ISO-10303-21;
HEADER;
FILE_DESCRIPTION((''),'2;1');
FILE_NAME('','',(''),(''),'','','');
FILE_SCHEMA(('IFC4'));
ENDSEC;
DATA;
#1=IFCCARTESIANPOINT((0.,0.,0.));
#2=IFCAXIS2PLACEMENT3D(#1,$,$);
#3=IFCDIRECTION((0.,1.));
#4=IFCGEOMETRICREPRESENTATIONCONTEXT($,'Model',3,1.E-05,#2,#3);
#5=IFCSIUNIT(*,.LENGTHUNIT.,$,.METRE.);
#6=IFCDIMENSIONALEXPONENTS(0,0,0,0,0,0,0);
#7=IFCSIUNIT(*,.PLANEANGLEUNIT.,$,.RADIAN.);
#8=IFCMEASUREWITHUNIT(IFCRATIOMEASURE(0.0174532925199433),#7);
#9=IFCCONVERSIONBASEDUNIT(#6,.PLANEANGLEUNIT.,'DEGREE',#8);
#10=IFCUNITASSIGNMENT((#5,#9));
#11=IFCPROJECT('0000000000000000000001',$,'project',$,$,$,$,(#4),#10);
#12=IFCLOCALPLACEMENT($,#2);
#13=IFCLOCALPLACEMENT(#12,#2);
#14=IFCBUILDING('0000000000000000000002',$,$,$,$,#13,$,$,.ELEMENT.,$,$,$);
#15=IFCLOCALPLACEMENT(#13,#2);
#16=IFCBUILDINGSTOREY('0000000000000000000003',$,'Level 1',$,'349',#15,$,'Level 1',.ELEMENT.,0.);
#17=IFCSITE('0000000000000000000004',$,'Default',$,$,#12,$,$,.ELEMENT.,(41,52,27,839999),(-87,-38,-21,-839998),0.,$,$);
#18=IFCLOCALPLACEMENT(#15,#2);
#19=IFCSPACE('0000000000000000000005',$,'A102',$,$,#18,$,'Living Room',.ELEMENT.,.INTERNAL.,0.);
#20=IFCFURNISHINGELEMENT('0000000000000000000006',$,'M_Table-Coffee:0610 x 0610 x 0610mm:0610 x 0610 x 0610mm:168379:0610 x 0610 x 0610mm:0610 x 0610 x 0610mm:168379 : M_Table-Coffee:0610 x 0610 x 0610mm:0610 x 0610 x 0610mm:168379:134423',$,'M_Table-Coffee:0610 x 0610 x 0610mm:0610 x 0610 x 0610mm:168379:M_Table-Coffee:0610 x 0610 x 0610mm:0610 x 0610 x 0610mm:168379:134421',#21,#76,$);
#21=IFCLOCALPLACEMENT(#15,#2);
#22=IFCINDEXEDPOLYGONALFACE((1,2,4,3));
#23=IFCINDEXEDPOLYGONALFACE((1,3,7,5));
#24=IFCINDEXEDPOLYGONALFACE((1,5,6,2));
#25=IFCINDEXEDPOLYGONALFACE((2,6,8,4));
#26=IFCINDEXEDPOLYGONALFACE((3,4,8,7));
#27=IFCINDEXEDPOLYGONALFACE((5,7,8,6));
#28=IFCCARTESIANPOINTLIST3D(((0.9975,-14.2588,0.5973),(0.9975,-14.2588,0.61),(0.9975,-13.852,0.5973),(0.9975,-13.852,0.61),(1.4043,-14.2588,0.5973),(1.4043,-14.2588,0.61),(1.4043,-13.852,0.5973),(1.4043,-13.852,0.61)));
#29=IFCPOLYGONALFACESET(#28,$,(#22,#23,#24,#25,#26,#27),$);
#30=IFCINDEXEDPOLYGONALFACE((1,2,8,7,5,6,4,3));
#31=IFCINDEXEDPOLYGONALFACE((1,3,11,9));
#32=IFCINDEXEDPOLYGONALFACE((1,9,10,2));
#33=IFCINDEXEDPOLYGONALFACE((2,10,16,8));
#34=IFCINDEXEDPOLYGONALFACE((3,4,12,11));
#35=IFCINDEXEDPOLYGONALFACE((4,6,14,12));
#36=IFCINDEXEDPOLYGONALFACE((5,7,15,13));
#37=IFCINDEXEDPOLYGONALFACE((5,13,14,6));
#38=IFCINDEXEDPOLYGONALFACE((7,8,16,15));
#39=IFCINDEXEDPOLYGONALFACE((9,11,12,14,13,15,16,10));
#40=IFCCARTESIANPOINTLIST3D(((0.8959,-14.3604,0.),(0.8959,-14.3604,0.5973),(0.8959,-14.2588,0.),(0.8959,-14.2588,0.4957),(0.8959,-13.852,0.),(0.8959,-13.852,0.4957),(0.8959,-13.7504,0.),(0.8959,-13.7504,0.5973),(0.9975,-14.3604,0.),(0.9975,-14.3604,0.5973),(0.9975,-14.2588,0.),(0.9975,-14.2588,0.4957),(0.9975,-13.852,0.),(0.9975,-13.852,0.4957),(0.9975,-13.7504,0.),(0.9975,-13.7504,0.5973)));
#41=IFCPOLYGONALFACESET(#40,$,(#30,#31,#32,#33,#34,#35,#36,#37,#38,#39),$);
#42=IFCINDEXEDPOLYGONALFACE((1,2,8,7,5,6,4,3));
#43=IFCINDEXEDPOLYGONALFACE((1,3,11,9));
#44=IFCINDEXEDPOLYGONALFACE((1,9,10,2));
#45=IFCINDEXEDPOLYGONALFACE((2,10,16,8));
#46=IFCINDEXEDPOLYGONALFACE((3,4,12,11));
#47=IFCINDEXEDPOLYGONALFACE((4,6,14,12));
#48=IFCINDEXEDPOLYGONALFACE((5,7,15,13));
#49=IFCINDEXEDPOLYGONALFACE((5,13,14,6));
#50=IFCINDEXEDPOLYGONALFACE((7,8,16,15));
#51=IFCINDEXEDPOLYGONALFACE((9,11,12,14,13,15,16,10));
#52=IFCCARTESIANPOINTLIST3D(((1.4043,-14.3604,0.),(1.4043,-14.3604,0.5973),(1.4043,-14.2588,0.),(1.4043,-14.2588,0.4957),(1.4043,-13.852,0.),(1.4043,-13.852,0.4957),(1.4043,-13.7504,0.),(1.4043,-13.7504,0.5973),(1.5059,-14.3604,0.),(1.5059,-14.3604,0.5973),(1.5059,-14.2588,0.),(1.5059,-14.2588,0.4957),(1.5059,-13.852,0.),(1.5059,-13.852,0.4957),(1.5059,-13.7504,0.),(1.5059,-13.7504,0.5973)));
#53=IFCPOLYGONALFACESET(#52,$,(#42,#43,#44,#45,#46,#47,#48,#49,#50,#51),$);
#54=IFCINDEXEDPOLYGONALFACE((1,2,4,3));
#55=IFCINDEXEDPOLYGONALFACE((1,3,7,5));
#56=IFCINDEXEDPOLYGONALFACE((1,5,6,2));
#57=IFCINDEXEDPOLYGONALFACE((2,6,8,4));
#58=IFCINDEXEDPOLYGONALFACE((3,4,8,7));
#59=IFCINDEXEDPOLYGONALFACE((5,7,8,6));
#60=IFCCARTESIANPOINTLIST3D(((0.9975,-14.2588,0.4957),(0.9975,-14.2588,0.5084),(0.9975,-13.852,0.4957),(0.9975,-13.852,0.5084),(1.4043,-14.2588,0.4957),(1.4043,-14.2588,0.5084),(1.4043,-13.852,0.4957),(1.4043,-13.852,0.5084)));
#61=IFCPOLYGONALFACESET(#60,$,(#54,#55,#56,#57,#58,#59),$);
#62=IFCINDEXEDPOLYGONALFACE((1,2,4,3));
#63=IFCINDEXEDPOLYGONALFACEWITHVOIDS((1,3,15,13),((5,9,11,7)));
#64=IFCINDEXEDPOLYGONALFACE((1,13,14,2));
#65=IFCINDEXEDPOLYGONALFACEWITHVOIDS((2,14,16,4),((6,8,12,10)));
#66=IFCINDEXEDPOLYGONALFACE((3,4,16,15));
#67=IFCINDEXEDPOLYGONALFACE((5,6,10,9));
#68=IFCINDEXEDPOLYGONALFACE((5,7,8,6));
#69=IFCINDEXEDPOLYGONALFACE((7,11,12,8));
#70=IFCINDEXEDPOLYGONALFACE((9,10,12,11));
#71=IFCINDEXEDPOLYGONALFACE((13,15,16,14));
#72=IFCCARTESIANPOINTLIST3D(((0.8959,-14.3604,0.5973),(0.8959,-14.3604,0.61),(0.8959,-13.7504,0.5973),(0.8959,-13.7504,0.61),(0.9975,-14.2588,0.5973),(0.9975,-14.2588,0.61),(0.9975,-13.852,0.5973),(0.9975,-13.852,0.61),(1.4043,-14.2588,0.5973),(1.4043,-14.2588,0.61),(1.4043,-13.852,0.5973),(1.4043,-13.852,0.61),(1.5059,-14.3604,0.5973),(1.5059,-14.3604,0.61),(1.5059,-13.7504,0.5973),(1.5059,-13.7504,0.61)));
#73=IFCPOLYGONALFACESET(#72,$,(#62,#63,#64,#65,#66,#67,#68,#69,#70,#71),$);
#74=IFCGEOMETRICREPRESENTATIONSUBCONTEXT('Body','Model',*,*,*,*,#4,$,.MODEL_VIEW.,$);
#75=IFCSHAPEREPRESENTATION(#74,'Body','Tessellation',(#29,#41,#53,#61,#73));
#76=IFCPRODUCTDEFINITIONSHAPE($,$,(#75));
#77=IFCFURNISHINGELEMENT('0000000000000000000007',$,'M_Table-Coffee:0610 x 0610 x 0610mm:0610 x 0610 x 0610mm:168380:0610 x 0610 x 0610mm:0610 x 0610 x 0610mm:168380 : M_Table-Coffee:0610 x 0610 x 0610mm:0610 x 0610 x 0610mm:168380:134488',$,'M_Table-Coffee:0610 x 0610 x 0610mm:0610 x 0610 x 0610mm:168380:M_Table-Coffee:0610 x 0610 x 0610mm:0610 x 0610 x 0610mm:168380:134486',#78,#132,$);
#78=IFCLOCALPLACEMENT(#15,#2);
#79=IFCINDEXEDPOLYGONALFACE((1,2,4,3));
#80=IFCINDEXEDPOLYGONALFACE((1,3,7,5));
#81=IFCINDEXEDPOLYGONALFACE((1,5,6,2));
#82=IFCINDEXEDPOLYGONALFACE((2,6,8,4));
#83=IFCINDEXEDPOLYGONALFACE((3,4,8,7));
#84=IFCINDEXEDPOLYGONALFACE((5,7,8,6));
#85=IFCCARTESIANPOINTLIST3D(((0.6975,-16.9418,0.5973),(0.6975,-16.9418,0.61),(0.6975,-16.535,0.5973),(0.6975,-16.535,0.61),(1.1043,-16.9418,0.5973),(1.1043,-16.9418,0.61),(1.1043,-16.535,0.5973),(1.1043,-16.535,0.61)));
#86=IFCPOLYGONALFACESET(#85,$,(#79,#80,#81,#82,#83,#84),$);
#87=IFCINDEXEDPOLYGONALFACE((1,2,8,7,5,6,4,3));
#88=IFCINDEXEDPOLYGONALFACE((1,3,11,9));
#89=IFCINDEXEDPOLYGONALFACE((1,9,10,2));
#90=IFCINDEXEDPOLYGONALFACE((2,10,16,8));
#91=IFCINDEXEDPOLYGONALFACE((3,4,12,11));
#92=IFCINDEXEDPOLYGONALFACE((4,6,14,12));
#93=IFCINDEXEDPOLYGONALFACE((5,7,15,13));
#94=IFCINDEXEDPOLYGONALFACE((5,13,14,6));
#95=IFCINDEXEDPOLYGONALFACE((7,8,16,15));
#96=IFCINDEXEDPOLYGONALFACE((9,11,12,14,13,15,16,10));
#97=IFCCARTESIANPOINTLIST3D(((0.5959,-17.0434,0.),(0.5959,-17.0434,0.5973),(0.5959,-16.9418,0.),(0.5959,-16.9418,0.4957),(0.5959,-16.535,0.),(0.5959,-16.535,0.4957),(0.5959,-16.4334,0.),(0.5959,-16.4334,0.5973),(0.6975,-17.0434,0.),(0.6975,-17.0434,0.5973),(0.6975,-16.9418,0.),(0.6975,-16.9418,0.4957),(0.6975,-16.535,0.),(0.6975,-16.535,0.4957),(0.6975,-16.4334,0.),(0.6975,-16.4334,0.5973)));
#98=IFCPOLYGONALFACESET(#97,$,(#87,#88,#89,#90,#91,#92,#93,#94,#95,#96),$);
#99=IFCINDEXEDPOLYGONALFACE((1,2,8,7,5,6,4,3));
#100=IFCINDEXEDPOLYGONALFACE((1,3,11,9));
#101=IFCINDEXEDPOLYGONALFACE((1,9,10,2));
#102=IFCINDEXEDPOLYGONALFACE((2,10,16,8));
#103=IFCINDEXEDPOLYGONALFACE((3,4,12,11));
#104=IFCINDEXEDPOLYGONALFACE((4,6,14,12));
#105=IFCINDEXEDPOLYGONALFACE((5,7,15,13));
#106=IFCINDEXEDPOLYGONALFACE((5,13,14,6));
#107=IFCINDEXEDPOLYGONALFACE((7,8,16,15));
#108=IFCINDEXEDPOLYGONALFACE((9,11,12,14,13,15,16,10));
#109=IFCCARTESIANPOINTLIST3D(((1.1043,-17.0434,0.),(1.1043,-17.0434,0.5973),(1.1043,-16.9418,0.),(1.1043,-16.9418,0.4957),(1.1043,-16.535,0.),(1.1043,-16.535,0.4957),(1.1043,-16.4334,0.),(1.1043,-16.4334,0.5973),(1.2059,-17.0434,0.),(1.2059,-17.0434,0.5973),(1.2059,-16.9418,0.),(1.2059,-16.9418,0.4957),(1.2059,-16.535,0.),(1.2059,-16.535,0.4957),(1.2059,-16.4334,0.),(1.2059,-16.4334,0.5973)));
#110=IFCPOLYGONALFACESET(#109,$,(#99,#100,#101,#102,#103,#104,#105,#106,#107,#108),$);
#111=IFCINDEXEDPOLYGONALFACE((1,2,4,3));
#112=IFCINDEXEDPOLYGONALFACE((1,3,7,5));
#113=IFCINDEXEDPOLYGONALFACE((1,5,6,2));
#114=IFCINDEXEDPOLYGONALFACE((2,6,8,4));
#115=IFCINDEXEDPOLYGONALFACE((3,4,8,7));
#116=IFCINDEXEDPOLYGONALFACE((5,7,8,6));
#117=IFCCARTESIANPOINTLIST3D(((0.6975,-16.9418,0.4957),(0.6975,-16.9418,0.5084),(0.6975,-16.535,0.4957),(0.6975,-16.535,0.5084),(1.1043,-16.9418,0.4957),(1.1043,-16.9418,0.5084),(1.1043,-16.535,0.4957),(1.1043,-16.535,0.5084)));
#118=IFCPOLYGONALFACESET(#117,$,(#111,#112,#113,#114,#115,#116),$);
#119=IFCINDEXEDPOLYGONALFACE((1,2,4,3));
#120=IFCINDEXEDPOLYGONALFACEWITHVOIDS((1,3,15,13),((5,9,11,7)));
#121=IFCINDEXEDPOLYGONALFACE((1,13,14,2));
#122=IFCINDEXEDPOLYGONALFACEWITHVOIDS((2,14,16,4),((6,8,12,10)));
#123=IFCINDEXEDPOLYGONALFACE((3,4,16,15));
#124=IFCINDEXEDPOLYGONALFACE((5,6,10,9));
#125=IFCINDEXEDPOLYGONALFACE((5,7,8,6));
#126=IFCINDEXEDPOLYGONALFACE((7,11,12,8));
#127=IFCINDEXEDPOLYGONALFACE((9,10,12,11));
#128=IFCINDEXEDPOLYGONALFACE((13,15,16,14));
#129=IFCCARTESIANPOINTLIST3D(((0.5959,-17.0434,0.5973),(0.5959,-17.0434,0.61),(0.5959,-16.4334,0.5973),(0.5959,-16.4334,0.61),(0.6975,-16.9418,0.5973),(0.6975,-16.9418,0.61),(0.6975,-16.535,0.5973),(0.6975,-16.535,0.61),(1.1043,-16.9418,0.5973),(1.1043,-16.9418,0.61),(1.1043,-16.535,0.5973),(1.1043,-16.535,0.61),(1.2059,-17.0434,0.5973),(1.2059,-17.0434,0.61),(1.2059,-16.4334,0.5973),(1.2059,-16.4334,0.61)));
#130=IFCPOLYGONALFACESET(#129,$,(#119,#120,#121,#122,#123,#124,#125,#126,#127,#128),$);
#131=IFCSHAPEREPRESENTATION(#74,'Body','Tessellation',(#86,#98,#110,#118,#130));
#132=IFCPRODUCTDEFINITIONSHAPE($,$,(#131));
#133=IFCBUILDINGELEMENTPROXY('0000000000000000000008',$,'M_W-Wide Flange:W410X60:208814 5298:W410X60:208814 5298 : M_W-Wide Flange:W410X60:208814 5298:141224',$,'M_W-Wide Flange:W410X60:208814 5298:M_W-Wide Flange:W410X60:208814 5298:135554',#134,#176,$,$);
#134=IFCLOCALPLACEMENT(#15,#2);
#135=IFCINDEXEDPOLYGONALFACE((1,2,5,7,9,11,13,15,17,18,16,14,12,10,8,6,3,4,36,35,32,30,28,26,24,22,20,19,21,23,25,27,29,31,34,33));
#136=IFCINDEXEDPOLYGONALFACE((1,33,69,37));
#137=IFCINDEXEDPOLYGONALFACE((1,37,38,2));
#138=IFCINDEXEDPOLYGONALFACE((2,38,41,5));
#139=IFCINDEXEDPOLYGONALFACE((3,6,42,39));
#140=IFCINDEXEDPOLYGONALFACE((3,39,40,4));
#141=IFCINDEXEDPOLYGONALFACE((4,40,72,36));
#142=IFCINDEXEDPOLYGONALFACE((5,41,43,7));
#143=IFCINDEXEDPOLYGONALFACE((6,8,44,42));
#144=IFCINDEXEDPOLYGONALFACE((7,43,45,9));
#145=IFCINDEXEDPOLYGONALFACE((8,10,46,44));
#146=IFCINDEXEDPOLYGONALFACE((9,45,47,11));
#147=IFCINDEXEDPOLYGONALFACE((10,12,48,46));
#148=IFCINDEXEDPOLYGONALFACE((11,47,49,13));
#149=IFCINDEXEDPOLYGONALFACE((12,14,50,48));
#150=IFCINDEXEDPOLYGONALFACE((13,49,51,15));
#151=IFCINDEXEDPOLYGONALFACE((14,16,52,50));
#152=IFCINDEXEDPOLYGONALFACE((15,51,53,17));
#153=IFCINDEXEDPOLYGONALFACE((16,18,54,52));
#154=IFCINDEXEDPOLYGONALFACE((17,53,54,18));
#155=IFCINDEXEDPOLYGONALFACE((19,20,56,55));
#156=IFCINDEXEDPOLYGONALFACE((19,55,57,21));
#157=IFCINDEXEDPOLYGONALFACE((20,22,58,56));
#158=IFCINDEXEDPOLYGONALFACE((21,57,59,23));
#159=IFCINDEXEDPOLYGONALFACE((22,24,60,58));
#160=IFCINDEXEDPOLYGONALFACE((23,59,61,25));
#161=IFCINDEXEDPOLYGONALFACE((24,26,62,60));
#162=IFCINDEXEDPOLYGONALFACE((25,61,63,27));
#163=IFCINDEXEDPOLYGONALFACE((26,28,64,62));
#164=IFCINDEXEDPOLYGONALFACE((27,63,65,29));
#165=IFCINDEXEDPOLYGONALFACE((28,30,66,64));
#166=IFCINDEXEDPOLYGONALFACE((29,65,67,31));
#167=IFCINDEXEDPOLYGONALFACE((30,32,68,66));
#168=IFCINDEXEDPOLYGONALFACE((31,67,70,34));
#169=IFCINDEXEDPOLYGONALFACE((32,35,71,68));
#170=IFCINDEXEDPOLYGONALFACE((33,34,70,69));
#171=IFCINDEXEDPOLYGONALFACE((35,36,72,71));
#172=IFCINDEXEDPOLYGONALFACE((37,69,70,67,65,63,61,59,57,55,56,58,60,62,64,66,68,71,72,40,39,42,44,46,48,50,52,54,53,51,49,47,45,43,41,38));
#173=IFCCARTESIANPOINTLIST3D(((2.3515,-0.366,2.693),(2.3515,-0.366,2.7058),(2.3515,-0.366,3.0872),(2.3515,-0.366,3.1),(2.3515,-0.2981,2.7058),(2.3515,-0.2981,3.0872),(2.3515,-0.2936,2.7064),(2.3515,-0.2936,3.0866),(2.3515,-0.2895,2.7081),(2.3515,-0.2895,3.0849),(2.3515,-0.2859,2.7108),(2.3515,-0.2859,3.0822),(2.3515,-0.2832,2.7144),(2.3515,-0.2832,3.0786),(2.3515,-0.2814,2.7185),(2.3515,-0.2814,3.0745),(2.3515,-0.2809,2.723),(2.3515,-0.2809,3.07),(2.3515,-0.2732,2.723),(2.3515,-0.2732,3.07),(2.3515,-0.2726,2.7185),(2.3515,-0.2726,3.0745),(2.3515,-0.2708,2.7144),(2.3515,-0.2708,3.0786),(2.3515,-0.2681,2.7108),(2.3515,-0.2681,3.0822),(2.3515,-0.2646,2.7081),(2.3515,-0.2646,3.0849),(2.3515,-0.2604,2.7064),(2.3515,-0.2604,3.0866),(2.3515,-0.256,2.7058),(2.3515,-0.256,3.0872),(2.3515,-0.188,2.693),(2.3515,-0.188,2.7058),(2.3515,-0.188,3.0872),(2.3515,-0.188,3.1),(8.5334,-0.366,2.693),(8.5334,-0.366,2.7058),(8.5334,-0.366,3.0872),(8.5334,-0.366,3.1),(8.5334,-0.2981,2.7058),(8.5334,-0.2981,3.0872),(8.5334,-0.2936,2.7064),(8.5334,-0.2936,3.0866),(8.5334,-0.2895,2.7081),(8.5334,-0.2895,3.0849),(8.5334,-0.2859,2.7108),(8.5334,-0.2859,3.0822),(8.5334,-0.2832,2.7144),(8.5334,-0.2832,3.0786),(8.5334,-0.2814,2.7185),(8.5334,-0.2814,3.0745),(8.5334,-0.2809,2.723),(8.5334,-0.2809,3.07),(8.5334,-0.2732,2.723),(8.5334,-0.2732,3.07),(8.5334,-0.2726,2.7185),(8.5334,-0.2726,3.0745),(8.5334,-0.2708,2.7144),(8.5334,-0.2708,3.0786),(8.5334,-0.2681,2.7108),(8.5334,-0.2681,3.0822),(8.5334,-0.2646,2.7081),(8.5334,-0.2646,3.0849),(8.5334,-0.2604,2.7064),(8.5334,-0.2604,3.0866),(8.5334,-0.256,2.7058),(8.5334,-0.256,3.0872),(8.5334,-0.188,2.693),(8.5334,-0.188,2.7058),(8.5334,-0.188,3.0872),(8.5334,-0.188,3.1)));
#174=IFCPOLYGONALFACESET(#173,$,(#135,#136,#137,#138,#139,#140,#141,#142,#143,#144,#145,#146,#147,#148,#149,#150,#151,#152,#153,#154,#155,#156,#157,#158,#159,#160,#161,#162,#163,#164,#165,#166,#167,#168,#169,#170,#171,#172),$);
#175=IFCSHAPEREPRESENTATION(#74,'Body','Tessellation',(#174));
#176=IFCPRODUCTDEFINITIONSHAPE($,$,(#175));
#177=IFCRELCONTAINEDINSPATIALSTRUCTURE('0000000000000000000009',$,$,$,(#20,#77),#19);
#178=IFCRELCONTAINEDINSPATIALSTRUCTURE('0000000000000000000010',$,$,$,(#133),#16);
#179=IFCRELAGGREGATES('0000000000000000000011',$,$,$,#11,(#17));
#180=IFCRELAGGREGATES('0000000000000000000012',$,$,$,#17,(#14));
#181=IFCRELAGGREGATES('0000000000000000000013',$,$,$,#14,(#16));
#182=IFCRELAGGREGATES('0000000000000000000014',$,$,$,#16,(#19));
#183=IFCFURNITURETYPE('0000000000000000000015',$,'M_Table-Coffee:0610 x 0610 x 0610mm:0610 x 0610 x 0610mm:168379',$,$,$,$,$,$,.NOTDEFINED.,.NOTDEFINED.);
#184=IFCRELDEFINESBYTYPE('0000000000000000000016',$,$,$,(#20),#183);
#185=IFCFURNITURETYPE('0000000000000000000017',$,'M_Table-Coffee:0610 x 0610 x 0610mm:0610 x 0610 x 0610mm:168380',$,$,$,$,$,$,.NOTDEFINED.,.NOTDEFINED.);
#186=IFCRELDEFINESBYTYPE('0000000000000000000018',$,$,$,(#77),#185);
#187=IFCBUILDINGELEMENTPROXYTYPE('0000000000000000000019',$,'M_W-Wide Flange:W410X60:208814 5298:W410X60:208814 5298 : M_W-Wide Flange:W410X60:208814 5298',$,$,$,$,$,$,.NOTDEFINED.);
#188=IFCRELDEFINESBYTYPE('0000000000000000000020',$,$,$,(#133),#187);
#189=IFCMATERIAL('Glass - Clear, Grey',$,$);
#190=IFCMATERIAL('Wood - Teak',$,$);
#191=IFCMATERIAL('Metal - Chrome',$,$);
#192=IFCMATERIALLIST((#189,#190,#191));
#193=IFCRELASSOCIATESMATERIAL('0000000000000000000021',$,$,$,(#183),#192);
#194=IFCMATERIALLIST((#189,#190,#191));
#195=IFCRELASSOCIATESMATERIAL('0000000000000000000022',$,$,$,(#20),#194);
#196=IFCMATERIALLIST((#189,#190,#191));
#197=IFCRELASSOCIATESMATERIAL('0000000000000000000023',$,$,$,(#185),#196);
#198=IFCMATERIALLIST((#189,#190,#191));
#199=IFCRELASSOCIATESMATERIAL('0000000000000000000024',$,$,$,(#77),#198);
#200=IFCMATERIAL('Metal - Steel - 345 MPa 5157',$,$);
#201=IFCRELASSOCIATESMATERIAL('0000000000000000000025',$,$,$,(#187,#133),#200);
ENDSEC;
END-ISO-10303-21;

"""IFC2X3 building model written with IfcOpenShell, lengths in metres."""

from ifc_helpers import new_model, entity, si_unit, converted_unit, direction, frame, frame_2d, origin, place, context, subcontext, project, spatial, polyline, rectangle, i_section, outline, extrude, source, transform, mapped, material, material_list, type_object, type_shapes, element, save


model = new_model("IFC2X3")

# Units and contexts
model_context = context("Model", 3, precision=1e-05, world=origin(), true_north=direction((0.0, 1.0)))
body_context = subcontext(model_context, "Body", "Model", "MODEL_VIEW")
ifc_project = project(units=[si_unit("LENGTHUNIT", "METRE"), converted_unit("PLANEANGLEUNIT", "DEGREE", entity("IfcRatioMeasure", 0.0174532925199433), si_unit("PLANEANGLEUNIT", "RADIAN"), dimensions=[0, 0, 0, 0, 0, 0, 0])], contexts=[model_context])

# Site, building, storey
site_placement = place(None, origin())
site = spatial("IfcSite", under=ifc_project, at=site_placement, Name="Default", CompositionType="ELEMENT", RefLatitude=(41, 52, 27, 839999), RefLongitude=(-87, -38, -21, -839998), RefElevation=0.0)
building_placement = place(site_placement, origin())
building = spatial("IfcBuilding", under=site, at=building_placement, CompositionType="ELEMENT")
storey_placement = place(building_placement, origin())
storey = spatial("IfcBuildingStorey", under=building, at=storey_placement, Name="Level 1", ObjectType="349", LongName="Level 1", CompositionType="ELEMENT", Elevation=0.0)

# Shared definitions
ifc_material_1 = material(Name="Glass - Clear, Grey")
ifc_material_2 = material(Name="Wood - Teak")
ifc_material_3 = material(Name="Metal - Chrome")

# Shared definitions
space_1_placement = place(storey_placement, origin())
space_1 = spatial("IfcSpace", under=storey, at=space_1_placement, Name="A102", LongName="Living Room", CompositionType="ELEMENT", InteriorOrExteriorSpace="INTERNAL", ElevationWithFlooring=0.0)

# Furnishing elements
ifc_material_list_1 = material_list([ifc_material_1, ifc_material_2, ifc_material_3])
ifc_material_list_2 = material_list([ifc_material_1, ifc_material_2, ifc_material_3])
furniture_type_1 = type_object("IfcFurnitureType", Name="M_Table-Coffee:0610 x 0610 x 0610mm:0610 x 0610 x 0610mm:168379", material=ifc_material_list_2)
shared_shape_1 = source(origin(), body_context, "Body", "SweptSolid", [
    extrude(rectangle(XDim=0.4068, YDim=0.4068, at=frame_2d((0.0, 0.0), x_axis=(1.0, 0.0))), frame((1.2009, -14.0554, 0.5973), z_axis=(0.0, 0.0, 1.0), x_axis=(0.0, 1.0, 0.0)), (0.0, 0.0, 1.0), 0.0127),
    extrude(outline(polyline([(-0.324, -0.305), (0.2732, -0.305), (0.2732, -0.2034), (-0.2225, -0.2034), (-0.2225, 0.2034), (0.2732, 0.2034), (0.2732, 0.305), (-0.324, 0.305), (-0.324, -0.305)])), frame((0.8959, -14.0554, 0.2732), z_axis=(1.0, 0.0, 0.0), x_axis=(0.0, 0.0, -1.0)), (0.0, 0.0, 1.0), 0.1016),
    extrude(outline(polyline([(-0.305, -0.3241), (0.305, -0.3241), (0.305, 0.2733), (0.2034, 0.2733), (0.2034, -0.2224), (-0.2034, -0.2224), (-0.2034, 0.2733), (-0.305, 0.2733), (-0.305, -0.3241)])), frame((1.4043, -14.0554, 0.2733), z_axis=(1.0, 0.0, 0.0), x_axis=(0.0, -1.0, 0.0)), (0.0, 0.0, 1.0), 0.1016),
    extrude(rectangle(XDim=0.4068, YDim=0.4068, at=frame_2d((0.0, 0.0), x_axis=(1.0, 0.0))), frame((1.2009, -14.0554, 0.4957), z_axis=(0.0, 0.0, 1.0), x_axis=(0.0, 1.0, 0.0)), (0.0, 0.0, 1.0), 0.0127),
    extrude(outline(polyline([(-0.305, -0.305), (0.305, -0.305), (0.305, 0.305), (-0.305, 0.305), (-0.305, -0.305)]), holes=[polyline([(0.2034, 0.2034), (0.2034, -0.2034), (-0.2034, -0.2034), (-0.2034, 0.2034), (0.2034, 0.2034)])]), frame((1.2009, -14.0554, 0.5973), z_axis=(0.0, 0.0, 1.0), x_axis=(0.0, 1.0, 0.0)), (0.0, 0.0, 1.0), 0.0127),
])
type_shapes(furniture_type_1, [shared_shape_1])
furnishing_1_placement = place(space_1_placement, origin())
element("IfcFurnishingElement", 1, at=furnishing_1_placement, inside=space_1, type_object=furniture_type_1, material=ifc_material_list_1, Name="M_Table-Coffee:0610 x 0610 x 0610mm:0610 x 0610 x 0610mm:168379:0610 x 0610 x 0610mm:0610 x 0610 x 0610mm:168379 : M_Table-Coffee:0610 x 0610 x 0610mm:0610 x 0610 x 0610mm:168379:134423", ObjectType="M_Table-Coffee:0610 x 0610 x 0610mm:0610 x 0610 x 0610mm:168379:M_Table-Coffee:0610 x 0610 x 0610mm:0610 x 0610 x 0610mm:168379:134421", context=body_context, shape_type="MappedRepresentation", body=[
    mapped(shared_shape_1, transform((0.0, 0.0, 0.0), scale=1.0)),
])
ifc_material_list_3 = material_list([ifc_material_1, ifc_material_2, ifc_material_3])
ifc_material_list_4 = material_list([ifc_material_1, ifc_material_2, ifc_material_3])
furniture_type_2 = type_object("IfcFurnitureType", Name="M_Table-Coffee:0610 x 0610 x 0610mm:0610 x 0610 x 0610mm:168380", material=ifc_material_list_4)
shared_shape_2 = source(origin(), body_context, "Body", "SweptSolid", [
    extrude(rectangle(XDim=0.4068, YDim=0.4068, at=frame_2d((0.0, 0.0), x_axis=(1.0, 0.0))), frame((0.9009, -16.7384, 0.5973), z_axis=(0.0, 0.0, 1.0), x_axis=(0.0, 1.0, 0.0)), (0.0, 0.0, 1.0), 0.0127),
    extrude(outline(polyline([(-0.324, -0.305), (0.2732, -0.305), (0.2732, -0.2034), (-0.2225, -0.2034), (-0.2225, 0.2034), (0.2732, 0.2034), (0.2732, 0.305), (-0.324, 0.305), (-0.324, -0.305)])), frame((0.5959, -16.7384, 0.2732), z_axis=(1.0, 0.0, 0.0), x_axis=(0.0, 0.0, -1.0)), (0.0, 0.0, 1.0), 0.1016),
    extrude(outline(polyline([(-0.305, -0.3241), (0.305, -0.3241), (0.305, 0.2733), (0.2034, 0.2733), (0.2034, -0.2224), (-0.2034, -0.2224), (-0.2034, 0.2733), (-0.305, 0.2733), (-0.305, -0.3241)])), frame((1.1043, -16.7384, 0.2733), z_axis=(1.0, 0.0, 0.0), x_axis=(0.0, -1.0, 0.0)), (0.0, 0.0, 1.0), 0.1016),
    extrude(rectangle(XDim=0.4068, YDim=0.4068, at=frame_2d((0.0, 0.0), x_axis=(1.0, 0.0))), frame((0.9009, -16.7384, 0.4957), z_axis=(0.0, 0.0, 1.0), x_axis=(0.0, 1.0, 0.0)), (0.0, 0.0, 1.0), 0.0127),
    extrude(outline(polyline([(-0.305, -0.305), (0.305, -0.305), (0.305, 0.305), (-0.305, 0.305), (-0.305, -0.305)]), holes=[polyline([(0.2034, 0.2034), (0.2034, -0.2034), (-0.2034, -0.2034), (-0.2034, 0.2034), (0.2034, 0.2034)])]), frame((0.9009, -16.7384, 0.5973), z_axis=(0.0, 0.0, 1.0), x_axis=(0.0, 1.0, 0.0)), (0.0, 0.0, 1.0), 0.0127),
])
type_shapes(furniture_type_2, [shared_shape_2])
furnishing_2_placement = place(space_1_placement, origin())
element("IfcFurnishingElement", 2, at=furnishing_2_placement, inside=space_1, type_object=furniture_type_2, material=ifc_material_list_3, Name="M_Table-Coffee:0610 x 0610 x 0610mm:0610 x 0610 x 0610mm:168380:0610 x 0610 x 0610mm:0610 x 0610 x 0610mm:168380 : M_Table-Coffee:0610 x 0610 x 0610mm:0610 x 0610 x 0610mm:168380:134488", ObjectType="M_Table-Coffee:0610 x 0610 x 0610mm:0610 x 0610 x 0610mm:168380:M_Table-Coffee:0610 x 0610 x 0610mm:0610 x 0610 x 0610mm:168380:134486", context=body_context, shape_type="MappedRepresentation", body=[
    mapped(shared_shape_2, transform((0.0, 0.0, 0.0), scale=1.0)),
])

# Building element proxy
ifc_material_4 = material(Name="Metal - Steel - 345 MPa 5157")
building_element_proxy_type = type_object("IfcBuildingElementProxyType", Name="M_W-Wide Flange:W410X60:208814 5298:W410X60:208814 5298 : M_W-Wide Flange:W410X60:208814 5298", PredefinedType="NOTDEFINED", material=ifc_material_4)
shared_shape_3 = source(origin(), body_context, "Body", "SweptSolid", [
    extrude(i_section(OverallWidth=0.178, OverallDepth=0.407, WebThickness=0.0077, FlangeThickness=0.0128, FilletRadius=0.0172, at=frame_2d((0.0, 0.0), x_axis=(0.0, 1.0))), frame((0.0, 0.0581, -0.2035), z_axis=(0.0, 1.0, 0.0), x_axis=(0.0, 0.0, 1.0)), (0.0, 0.0, 1.0), 6.1819),
])
type_shapes(building_element_proxy_type, [shared_shape_3])
proxy_placement = place(storey_placement, frame((8.5915, -0.277, 3.1), z_axis=(0.0, 0.0, 1.0), x_axis=(0.0, 1.0, 0.0)))
element("IfcBuildingElementProxy", 3, at=proxy_placement, inside=storey, type_object=building_element_proxy_type, material=ifc_material_4, Name="M_W-Wide Flange:W410X60:208814 5298:W410X60:208814 5298 : M_W-Wide Flange:W410X60:208814 5298:141224", ObjectType="M_W-Wide Flange:W410X60:208814 5298:M_W-Wide Flange:W410X60:208814 5298:135554", context=body_context, shape_type="MappedRepresentation", body=[
    mapped(shared_shape_3, transform((0.0, 0.0, 0.0), scale=1.0)),
])

save(model, "model.ifc")
